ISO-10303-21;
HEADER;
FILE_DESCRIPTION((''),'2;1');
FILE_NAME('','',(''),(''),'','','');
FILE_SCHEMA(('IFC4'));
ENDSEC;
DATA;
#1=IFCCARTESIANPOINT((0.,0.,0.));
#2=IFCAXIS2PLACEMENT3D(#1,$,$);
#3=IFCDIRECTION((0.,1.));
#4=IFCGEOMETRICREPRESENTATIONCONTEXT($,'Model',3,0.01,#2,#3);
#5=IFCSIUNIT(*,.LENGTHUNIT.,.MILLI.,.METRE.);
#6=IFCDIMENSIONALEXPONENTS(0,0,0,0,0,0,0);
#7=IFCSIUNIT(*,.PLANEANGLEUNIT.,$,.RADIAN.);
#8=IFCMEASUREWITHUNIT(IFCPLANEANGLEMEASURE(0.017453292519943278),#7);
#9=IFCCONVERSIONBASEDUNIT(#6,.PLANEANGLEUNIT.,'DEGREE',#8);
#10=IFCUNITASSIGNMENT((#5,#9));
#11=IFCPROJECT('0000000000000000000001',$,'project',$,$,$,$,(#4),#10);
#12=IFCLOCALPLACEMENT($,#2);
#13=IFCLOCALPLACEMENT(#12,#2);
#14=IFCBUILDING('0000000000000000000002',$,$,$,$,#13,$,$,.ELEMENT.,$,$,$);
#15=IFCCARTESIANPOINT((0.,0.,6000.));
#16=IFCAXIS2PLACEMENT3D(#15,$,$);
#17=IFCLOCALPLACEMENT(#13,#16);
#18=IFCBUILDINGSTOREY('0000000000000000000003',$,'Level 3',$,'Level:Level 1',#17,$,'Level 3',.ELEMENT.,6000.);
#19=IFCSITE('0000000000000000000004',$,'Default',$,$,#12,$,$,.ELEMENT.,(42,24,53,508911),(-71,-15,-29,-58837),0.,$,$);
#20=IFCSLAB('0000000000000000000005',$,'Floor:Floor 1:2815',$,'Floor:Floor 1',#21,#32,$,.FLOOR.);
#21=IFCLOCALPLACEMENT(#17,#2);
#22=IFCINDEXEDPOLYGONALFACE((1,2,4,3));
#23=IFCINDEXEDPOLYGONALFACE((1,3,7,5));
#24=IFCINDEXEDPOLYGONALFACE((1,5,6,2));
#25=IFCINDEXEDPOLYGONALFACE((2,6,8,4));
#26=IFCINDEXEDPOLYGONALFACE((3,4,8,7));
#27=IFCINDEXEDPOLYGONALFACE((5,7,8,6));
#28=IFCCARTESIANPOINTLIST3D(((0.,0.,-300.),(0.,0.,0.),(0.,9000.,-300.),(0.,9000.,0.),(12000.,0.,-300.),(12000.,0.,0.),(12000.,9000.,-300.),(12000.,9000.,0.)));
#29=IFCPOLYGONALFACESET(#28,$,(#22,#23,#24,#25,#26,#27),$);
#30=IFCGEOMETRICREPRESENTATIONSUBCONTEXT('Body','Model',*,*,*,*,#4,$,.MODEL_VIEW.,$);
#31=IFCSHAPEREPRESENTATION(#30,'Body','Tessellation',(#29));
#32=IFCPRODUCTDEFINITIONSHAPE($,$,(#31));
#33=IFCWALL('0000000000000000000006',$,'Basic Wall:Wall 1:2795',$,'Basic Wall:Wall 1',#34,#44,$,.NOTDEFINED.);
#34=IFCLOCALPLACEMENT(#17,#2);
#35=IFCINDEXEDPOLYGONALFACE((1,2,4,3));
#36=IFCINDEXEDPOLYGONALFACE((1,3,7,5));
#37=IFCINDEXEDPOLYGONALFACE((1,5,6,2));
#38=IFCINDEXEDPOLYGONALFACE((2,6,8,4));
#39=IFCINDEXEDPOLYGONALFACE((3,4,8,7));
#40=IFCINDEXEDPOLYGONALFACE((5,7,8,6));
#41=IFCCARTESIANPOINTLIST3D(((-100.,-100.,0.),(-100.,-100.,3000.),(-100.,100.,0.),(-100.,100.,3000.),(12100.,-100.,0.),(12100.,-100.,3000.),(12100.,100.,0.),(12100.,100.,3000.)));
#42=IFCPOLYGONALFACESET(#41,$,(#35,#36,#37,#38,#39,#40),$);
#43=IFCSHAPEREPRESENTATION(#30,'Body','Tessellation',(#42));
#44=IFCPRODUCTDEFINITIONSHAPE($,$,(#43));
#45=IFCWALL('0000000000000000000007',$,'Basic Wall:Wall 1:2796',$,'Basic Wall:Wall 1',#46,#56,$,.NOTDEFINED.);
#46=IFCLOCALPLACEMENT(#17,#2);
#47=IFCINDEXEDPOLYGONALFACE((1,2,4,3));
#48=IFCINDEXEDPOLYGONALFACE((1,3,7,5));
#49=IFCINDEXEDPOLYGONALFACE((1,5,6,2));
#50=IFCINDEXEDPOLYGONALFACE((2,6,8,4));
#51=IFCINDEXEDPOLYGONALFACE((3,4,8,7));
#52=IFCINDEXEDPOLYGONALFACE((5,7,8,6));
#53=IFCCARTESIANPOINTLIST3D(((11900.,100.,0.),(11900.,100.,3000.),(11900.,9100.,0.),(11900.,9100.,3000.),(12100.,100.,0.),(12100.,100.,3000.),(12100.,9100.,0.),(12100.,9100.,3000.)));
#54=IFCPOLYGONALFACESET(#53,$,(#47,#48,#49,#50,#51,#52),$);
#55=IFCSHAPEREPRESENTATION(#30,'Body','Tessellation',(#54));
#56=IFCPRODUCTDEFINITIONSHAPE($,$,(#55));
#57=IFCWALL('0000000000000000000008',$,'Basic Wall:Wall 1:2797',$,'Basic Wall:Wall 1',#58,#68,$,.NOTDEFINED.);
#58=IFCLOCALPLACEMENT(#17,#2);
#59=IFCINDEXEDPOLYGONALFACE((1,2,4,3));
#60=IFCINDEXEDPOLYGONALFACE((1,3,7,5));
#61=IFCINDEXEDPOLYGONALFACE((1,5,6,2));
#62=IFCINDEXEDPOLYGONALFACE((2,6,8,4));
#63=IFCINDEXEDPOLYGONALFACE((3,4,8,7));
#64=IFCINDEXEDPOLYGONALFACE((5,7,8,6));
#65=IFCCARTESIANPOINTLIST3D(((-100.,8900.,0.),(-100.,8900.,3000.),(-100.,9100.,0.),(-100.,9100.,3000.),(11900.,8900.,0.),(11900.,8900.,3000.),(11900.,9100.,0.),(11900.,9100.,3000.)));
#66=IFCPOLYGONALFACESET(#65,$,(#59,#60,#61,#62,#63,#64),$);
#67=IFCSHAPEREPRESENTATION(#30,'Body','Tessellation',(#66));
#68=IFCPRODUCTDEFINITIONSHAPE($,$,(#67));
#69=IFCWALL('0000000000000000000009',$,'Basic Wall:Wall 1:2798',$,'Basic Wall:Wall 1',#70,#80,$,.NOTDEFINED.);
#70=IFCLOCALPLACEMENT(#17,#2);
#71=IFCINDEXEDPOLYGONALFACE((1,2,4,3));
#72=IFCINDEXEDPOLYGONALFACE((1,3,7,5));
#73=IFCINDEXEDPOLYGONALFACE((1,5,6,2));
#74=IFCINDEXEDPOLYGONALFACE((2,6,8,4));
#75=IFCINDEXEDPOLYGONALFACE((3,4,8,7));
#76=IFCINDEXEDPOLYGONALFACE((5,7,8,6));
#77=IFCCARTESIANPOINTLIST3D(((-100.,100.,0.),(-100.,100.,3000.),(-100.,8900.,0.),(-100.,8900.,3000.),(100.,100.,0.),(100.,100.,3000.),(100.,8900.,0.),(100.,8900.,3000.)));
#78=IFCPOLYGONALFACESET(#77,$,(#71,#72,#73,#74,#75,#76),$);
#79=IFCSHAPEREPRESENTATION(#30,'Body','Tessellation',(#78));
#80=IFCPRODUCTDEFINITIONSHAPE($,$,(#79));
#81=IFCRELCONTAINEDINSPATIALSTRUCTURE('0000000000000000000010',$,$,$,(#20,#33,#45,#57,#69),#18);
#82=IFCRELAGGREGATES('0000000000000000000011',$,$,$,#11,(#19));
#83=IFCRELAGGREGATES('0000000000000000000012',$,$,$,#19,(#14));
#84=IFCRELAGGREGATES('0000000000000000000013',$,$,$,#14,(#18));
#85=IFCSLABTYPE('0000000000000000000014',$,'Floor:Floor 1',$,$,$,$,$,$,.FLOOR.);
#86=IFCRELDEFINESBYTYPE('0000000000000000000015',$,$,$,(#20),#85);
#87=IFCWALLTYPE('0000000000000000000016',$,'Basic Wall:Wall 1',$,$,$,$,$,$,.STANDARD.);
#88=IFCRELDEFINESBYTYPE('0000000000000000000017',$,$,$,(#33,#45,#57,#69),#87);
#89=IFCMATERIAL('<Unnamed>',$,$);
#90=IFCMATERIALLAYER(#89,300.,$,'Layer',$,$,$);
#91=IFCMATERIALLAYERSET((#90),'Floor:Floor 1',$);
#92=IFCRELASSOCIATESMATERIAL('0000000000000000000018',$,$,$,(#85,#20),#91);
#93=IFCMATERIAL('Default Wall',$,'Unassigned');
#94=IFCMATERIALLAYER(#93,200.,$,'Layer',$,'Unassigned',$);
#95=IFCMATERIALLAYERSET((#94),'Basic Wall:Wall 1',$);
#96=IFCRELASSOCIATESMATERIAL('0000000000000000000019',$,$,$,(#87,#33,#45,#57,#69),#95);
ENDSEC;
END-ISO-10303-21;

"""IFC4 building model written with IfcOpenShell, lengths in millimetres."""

from ifc_helpers import new_model, entity, si_unit, converted_unit, direction, frame, frame_2d, origin, origin_2d_with_axis, place, context, subcontext, project, spatial, rectangle, extrude, material, layer, layer_set, layer_usage, type_object, element, save


model = new_model("IFC4")

# Units and contexts
model_context = context("Model", 3, precision=0.01, world=origin(), true_north=direction((0.0, 1.0)))
body_context = subcontext(model_context, "Body", "Model", "MODEL_VIEW")
ifc_project = project(units=[si_unit("LENGTHUNIT", "METRE", prefix="MILLI"), converted_unit("PLANEANGLEUNIT", "DEGREE", entity("IfcPlaneAngleMeasure", 0.017453292519943278), si_unit("PLANEANGLEUNIT", "RADIAN"), dimensions=[0, 0, 0, 0, 0, 0, 0])], contexts=[model_context])

# Site, building, storey
site_placement = place(None, origin())
site = spatial("IfcSite", under=ifc_project, at=site_placement, Name="Default", CompositionType="ELEMENT", RefLatitude=(42, 24, 53, 508911), RefLongitude=(-71, -15, -29, -58837), RefElevation=0.0)
building_placement = place(site_placement, origin())
building = spatial("IfcBuilding", under=site, at=building_placement, CompositionType="ELEMENT")
storey_placement = place(building_placement, frame((0.0, 0.0, 6000.0)))
storey = spatial("IfcBuildingStorey", under=building, at=storey_placement, Name="Level 3", ObjectType="Level:Level 1", LongName="Level 3", CompositionType="ELEMENT", Elevation=6000.0)

# Slab
ifc_material_1 = material(Name="<Unnamed>")
ifc_layer_1 = layer(ifc_material_1, 300.0, Name="Layer")
ifc_layer_set_1 = layer_set([ifc_layer_1], Name="Floor:Floor 1")
ifc_layer_usage_1 = layer_usage(ifc_layer_set_1, "AXIS3", "POSITIVE", 0.0)
slab_type = type_object("IfcSlabType", Name="Floor:Floor 1", PredefinedType="FLOOR", material=ifc_layer_set_1)
slab_placement = place(storey_placement, origin())
element("IfcSlab", 1, at=slab_placement, inside=storey, type_object=slab_type, material=ifc_layer_usage_1, Name="Floor:Floor 1:2815", ObjectType="Floor:Floor 1", PredefinedType="FLOOR", context=body_context, shape_type="SweptSolid", body=[
    extrude(rectangle(XDim=9000.0, YDim=12000.0, at=origin_2d_with_axis()), frame((6000.0, 4500.0, 0.0), z_axis=(0.0, 0.0, -1.0), x_axis=(0.0, 1.0, 0.0)), (0.0, 0.0, 1.0), 300.0),
])

# Walls
ifc_material_2 = material(Name="Default Wall", Category="Unassigned")
ifc_layer_2 = layer(ifc_material_2, 200.0, Name="Layer", Category="Unassigned")
ifc_layer_set_2 = layer_set([ifc_layer_2], Name="Basic Wall:Wall 1")
ifc_layer_usage_2 = layer_usage(ifc_layer_set_2, "AXIS2", "NEGATIVE", 100.0)
wall_type = type_object("IfcWallType", Name="Basic Wall:Wall 1", PredefinedType="STANDARD", material=ifc_layer_set_2)
wall_1_placement = place(storey_placement, frame((-100.0, 0.0, 0.0)))
element("IfcWall", 2, at=wall_1_placement, inside=storey, type_object=wall_type, material=ifc_layer_usage_2, Name="Basic Wall:Wall 1:2795", ObjectType="Basic Wall:Wall 1", PredefinedType="NOTDEFINED", context=body_context, shape_type="SweptSolid", body=[
    extrude(rectangle(XDim=12200.0, YDim=200.0, at=frame_2d((6100.0, 0.0), x_axis=(-1.0, 0.0))), origin(), (0.0, 0.0, 1.0), 3000.0),
])
ifc_layer_usage_3 = layer_usage(ifc_layer_set_2, "AXIS2", "NEGATIVE", 100.0)
wall_2_placement = place(storey_placement, frame((12000.0, 100.0, 0.0), z_axis=(0.0, 0.0, 1.0), x_axis=(0.0, 1.0, 0.0)))
element("IfcWall", 3, at=wall_2_placement, inside=storey, type_object=wall_type, material=ifc_layer_usage_3, Name="Basic Wall:Wall 1:2796", ObjectType="Basic Wall:Wall 1", PredefinedType="NOTDEFINED", context=body_context, shape_type="SweptSolid", body=[
    extrude(rectangle(XDim=9000.0, YDim=200.0, at=frame_2d((4500.0, 0.0), x_axis=(-1.0, 0.0))), origin(), (0.0, 0.0, 1.0), 3000.0),
])
ifc_layer_usage_4 = layer_usage(ifc_layer_set_2, "AXIS2", "NEGATIVE", 100.0)
wall_3_placement = place(storey_placement, frame((11900.0, 9000.0, 0.0), z_axis=(0.0, 0.0, 1.0), x_axis=(-1.0, 0.0, 0.0)))
element("IfcWall", 4, at=wall_3_placement, inside=storey, type_object=wall_type, material=ifc_layer_usage_4, Name="Basic Wall:Wall 1:2797", ObjectType="Basic Wall:Wall 1", PredefinedType="NOTDEFINED", context=body_context, shape_type="SweptSolid", body=[
    extrude(rectangle(XDim=12000.0, YDim=200.0, at=frame_2d((6000.0, 0.0), x_axis=(-1.0, 0.0))), origin(), (0.0, 0.0, 1.0), 3000.0),
])
ifc_layer_usage_5 = layer_usage(ifc_layer_set_2, "AXIS2", "NEGATIVE", 100.0)
wall_4_placement = place(storey_placement, frame((0.0, 8900.0, 0.0), z_axis=(0.0, 0.0, 1.0), x_axis=(0.0, -1.0, 0.0)))
element("IfcWall", 5, at=wall_4_placement, inside=storey, type_object=wall_type, material=ifc_layer_usage_5, Name="Basic Wall:Wall 1:2798", ObjectType="Basic Wall:Wall 1", PredefinedType="NOTDEFINED", context=body_context, shape_type="SweptSolid", body=[
    extrude(rectangle(XDim=8800.0, YDim=200.0, at=frame_2d((4400.0, 0.0), x_axis=(-1.0, 0.0))), origin(), (0.0, 0.0, 1.0), 3000.0),
])

save(model, "model.ifc")
